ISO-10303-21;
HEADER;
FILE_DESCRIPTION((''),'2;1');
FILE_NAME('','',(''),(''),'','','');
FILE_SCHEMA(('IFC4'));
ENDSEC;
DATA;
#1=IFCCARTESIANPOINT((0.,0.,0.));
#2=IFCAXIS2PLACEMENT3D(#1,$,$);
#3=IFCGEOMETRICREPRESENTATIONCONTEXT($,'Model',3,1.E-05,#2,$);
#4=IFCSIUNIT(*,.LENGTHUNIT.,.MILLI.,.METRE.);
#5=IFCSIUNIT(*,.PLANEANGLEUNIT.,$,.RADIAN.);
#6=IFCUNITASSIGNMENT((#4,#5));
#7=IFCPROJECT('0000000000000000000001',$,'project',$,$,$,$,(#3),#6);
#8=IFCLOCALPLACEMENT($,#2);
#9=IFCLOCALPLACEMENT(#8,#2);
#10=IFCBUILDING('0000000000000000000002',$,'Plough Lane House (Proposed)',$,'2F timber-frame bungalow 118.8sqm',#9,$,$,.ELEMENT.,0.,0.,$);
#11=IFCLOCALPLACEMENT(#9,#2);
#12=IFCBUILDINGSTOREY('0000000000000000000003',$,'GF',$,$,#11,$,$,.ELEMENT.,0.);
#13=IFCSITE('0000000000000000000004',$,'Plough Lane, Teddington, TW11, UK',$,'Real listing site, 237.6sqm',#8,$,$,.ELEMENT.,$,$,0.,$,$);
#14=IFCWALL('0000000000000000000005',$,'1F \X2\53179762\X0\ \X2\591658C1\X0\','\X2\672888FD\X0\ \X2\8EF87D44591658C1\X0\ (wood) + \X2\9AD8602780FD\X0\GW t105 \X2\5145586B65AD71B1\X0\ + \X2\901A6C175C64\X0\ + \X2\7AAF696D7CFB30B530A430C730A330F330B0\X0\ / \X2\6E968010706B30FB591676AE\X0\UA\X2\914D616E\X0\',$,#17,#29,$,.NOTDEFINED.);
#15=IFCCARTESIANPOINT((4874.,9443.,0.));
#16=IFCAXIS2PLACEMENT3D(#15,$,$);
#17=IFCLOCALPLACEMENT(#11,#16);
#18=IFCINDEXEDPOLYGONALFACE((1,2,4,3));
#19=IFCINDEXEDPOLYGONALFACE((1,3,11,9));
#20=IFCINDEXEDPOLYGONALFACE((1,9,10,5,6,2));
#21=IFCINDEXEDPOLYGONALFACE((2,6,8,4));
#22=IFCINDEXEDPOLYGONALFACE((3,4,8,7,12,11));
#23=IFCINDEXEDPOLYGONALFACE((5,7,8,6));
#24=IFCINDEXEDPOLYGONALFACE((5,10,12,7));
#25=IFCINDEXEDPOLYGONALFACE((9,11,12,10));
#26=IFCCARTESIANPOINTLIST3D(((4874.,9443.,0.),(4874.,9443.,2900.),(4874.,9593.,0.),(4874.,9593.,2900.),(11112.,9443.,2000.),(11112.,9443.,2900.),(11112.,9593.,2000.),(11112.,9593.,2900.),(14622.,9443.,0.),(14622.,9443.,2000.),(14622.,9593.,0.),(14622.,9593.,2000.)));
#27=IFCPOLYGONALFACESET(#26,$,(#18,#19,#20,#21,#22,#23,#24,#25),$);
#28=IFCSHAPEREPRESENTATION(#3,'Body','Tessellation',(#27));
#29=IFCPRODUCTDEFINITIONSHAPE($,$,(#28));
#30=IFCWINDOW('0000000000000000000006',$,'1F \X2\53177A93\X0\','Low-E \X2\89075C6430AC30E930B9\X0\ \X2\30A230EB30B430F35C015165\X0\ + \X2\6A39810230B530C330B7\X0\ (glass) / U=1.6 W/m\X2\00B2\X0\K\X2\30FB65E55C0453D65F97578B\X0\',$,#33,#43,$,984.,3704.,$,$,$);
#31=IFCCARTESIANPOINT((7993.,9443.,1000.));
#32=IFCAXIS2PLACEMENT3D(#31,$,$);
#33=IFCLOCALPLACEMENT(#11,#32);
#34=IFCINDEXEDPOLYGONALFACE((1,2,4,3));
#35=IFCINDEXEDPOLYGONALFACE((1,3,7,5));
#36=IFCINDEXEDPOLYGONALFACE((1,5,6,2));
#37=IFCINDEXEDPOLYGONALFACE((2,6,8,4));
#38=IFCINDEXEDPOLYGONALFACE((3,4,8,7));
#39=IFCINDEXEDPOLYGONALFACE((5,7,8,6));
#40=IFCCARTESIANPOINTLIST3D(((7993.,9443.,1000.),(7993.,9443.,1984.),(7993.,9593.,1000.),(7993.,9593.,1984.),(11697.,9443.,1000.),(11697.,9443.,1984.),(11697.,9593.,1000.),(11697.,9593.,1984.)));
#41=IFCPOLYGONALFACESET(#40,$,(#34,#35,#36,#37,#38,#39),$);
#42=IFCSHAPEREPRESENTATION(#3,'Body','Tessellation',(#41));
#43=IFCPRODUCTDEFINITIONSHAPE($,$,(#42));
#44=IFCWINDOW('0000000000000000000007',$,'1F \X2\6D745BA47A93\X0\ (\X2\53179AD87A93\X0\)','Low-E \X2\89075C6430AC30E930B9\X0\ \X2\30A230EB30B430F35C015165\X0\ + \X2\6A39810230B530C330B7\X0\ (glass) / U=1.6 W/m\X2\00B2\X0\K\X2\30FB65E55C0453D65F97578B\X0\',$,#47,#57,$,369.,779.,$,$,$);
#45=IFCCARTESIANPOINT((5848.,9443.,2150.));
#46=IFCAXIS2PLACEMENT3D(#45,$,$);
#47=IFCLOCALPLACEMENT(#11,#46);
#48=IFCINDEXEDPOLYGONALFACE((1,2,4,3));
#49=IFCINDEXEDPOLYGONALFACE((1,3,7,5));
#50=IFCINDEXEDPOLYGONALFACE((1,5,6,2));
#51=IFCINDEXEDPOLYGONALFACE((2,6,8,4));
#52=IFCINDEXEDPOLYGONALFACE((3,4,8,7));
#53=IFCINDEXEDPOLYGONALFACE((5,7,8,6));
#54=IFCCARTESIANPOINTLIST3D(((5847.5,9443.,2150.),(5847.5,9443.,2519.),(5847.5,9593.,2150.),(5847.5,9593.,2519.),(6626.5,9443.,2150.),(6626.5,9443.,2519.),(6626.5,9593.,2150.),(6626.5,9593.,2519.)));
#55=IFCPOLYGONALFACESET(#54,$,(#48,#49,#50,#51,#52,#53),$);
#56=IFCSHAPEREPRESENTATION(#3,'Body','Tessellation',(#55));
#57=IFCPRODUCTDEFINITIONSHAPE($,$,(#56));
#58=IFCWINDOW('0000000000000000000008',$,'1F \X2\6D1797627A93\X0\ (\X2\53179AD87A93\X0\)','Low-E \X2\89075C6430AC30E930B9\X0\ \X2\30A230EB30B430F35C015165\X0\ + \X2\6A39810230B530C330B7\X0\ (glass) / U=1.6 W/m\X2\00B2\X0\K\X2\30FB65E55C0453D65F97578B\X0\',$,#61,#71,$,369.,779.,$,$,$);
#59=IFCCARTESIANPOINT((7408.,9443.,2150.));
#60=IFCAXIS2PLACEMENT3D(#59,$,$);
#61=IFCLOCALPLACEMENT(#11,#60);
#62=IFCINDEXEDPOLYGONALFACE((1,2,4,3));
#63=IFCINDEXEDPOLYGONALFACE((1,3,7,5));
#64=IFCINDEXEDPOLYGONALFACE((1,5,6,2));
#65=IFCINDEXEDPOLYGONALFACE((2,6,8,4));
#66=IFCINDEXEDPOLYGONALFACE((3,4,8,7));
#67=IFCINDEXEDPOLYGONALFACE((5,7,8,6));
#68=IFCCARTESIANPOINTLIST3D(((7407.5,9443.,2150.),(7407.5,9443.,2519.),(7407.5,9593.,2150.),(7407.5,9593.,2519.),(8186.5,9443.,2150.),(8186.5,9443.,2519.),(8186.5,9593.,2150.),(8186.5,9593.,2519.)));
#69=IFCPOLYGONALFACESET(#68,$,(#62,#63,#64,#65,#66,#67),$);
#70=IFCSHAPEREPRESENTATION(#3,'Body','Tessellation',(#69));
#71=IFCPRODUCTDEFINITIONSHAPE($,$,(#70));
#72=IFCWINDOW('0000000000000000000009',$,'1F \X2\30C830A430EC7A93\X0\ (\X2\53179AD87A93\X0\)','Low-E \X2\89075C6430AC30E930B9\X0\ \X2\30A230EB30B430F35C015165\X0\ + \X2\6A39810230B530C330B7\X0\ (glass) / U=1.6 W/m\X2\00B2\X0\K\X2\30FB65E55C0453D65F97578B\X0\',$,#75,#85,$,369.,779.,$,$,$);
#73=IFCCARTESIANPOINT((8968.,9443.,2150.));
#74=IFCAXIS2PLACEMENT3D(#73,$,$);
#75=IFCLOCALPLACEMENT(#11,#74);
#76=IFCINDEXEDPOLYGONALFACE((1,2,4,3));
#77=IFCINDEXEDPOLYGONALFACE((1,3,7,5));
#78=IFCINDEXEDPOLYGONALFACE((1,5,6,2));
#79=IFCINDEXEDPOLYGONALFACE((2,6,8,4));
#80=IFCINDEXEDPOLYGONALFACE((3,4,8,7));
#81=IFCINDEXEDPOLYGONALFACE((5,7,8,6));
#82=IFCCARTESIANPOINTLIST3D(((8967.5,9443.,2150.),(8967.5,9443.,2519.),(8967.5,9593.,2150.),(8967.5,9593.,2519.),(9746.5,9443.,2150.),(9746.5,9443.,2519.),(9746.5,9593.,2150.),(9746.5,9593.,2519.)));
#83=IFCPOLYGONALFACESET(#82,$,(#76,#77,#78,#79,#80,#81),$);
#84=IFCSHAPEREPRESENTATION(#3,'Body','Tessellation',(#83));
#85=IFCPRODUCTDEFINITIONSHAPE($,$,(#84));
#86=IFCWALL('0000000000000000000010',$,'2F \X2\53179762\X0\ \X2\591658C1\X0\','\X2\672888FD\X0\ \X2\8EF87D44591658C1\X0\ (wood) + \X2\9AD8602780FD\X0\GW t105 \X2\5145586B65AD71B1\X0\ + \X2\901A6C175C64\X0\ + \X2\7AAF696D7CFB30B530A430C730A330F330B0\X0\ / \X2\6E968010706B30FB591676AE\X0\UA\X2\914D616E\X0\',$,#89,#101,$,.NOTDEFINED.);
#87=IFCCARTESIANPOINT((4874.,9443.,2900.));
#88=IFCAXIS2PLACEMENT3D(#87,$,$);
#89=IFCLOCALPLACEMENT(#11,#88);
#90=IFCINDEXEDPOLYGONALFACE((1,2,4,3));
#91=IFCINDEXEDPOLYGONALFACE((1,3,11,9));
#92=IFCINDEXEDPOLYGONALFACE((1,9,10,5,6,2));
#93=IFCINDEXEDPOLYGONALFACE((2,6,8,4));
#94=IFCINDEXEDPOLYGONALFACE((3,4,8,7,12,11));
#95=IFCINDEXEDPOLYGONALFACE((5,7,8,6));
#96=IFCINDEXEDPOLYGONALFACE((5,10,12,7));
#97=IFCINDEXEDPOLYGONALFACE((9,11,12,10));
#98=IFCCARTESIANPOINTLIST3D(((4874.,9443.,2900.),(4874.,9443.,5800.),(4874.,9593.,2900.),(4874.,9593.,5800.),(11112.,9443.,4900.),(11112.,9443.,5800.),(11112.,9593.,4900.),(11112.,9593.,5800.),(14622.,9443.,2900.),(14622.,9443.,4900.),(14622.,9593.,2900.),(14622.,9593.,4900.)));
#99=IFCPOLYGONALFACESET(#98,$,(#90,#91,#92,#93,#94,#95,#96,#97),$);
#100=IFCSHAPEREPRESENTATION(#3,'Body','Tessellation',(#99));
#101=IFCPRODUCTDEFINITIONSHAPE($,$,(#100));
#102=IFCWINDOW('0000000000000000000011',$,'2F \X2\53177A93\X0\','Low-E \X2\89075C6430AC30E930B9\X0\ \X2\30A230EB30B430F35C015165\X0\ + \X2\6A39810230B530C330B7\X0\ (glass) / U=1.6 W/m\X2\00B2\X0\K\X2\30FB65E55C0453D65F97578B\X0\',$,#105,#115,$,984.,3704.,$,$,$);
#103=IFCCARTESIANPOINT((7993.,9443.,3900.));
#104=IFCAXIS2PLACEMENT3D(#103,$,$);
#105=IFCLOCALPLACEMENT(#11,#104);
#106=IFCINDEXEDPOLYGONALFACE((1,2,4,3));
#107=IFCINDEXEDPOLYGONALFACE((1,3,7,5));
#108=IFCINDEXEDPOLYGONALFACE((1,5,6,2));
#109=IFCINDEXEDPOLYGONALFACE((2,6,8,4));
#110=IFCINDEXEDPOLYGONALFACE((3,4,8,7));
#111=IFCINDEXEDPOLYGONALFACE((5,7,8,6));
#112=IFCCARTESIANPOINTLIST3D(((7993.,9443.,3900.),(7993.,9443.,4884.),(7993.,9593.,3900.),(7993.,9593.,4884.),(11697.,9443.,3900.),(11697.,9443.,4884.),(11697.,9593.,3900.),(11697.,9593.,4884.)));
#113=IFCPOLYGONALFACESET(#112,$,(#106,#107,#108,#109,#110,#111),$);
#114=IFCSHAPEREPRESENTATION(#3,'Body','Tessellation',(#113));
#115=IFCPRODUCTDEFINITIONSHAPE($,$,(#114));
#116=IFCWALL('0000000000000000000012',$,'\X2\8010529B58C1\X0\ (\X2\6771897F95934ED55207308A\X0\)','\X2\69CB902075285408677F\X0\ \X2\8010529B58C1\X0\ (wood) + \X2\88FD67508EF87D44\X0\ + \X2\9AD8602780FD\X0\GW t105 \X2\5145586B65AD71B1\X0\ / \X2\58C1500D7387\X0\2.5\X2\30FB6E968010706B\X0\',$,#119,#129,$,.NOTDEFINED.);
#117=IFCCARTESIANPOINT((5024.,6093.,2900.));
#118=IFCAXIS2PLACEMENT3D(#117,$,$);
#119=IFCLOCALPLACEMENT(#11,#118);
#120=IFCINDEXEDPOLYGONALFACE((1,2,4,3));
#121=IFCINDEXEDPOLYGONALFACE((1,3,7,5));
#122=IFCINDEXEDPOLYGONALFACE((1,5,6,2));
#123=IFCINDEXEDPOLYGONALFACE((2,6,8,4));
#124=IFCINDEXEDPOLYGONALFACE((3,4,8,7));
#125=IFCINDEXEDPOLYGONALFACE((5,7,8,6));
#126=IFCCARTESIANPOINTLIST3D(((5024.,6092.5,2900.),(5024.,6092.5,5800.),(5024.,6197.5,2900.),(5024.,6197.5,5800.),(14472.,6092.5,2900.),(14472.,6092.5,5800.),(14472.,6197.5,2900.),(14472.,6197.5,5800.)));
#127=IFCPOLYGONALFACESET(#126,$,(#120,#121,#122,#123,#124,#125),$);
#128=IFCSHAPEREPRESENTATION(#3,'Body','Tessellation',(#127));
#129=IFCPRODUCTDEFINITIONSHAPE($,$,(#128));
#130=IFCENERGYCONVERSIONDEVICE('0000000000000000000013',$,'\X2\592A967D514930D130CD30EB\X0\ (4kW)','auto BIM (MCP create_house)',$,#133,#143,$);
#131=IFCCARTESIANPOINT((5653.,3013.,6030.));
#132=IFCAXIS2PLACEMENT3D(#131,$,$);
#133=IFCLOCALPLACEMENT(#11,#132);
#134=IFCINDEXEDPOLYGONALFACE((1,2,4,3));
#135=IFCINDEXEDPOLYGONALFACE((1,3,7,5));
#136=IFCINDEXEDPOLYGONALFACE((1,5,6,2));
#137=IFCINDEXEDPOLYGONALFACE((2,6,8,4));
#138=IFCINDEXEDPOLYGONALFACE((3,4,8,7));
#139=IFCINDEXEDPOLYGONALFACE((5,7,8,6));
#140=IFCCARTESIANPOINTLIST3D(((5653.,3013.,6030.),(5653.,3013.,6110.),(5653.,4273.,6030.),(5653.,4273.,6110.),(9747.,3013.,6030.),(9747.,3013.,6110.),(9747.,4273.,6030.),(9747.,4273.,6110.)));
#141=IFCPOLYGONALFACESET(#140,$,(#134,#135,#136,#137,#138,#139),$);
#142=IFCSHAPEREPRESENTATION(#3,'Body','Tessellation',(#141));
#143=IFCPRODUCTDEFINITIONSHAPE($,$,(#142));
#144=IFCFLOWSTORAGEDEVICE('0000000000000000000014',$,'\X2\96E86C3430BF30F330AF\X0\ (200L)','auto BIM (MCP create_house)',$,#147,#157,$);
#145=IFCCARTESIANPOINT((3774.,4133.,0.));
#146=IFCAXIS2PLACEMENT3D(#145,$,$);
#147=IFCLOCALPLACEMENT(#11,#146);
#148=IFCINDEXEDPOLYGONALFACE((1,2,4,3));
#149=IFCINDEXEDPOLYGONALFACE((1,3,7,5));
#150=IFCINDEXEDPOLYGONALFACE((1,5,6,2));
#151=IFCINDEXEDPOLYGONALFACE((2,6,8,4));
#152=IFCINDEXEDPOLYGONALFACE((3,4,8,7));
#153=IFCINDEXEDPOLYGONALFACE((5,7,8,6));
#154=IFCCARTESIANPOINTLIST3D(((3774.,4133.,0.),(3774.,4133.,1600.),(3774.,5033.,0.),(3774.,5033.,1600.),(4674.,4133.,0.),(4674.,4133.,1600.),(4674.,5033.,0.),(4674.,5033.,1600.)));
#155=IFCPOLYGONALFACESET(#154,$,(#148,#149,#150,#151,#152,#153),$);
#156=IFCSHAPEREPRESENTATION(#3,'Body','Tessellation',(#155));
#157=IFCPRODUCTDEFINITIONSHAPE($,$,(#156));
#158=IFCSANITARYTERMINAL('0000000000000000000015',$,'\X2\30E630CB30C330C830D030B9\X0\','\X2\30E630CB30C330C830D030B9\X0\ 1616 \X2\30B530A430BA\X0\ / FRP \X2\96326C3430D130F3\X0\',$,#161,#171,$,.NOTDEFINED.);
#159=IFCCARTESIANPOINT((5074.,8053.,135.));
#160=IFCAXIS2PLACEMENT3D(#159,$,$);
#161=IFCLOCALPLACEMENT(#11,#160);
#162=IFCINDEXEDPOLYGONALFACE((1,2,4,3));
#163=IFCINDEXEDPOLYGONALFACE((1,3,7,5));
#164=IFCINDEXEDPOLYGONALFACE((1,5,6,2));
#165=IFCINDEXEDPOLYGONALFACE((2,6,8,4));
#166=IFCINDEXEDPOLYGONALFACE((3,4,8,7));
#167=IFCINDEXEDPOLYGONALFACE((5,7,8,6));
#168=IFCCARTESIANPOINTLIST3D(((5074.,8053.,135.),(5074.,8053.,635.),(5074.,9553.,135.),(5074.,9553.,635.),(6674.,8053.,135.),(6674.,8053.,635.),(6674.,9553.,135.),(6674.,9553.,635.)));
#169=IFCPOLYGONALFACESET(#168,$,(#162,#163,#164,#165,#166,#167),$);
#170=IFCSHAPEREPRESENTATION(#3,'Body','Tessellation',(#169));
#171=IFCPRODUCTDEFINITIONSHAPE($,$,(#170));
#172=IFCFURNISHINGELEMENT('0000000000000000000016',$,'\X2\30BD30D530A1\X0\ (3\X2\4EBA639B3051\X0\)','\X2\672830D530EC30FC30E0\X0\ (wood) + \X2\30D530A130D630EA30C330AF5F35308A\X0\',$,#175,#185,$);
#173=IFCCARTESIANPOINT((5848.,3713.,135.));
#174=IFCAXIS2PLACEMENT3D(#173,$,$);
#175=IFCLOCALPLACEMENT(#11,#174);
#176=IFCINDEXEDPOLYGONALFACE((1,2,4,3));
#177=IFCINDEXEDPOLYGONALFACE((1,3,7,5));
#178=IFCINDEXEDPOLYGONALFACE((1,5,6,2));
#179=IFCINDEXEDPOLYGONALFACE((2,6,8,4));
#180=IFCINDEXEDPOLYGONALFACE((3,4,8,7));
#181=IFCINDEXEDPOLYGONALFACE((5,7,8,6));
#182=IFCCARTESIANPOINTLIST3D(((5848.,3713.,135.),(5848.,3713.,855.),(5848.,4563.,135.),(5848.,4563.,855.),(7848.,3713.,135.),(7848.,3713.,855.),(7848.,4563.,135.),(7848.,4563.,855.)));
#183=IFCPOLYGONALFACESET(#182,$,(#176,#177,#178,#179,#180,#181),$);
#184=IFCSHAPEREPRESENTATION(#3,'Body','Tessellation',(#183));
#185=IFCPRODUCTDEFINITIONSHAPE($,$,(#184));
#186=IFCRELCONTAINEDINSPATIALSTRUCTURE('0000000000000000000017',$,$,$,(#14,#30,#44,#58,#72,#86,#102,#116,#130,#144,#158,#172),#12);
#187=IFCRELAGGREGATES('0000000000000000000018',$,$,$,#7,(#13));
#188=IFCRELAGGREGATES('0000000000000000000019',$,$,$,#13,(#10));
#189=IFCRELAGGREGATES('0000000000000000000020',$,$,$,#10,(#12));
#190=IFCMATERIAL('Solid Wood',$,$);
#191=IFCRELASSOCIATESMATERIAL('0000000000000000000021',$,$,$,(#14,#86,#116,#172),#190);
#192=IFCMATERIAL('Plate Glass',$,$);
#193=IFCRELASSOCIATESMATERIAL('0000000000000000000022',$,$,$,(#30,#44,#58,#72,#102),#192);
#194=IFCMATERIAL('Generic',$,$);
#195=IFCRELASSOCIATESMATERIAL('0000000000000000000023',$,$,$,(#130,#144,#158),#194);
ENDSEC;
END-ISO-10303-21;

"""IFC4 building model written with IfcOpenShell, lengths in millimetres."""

from ifc_helpers import new_model, si_unit, frame, frame_2d, origin, place, context, project, spatial, rectangle, extrude, material, element, fill, save


model = new_model("IFC4")

# Units and contexts
model_context = context("Model", 3, precision=1e-05, world=origin())
ifc_project = project(units=[si_unit("LENGTHUNIT", "METRE", prefix="MILLI"), si_unit("PLANEANGLEUNIT", "RADIAN")], contexts=[model_context])

# Site, building, storey
site_placement = place(None, origin())
site = spatial("IfcSite", under=ifc_project, at=site_placement, Name="Plough Lane, Teddington, TW11, UK", ObjectType="Real listing site, 237.6sqm", CompositionType="ELEMENT", RefElevation=0.0)
building_placement = place(site_placement, origin())
building = spatial("IfcBuilding", under=site, at=building_placement, Name="Plough Lane House (Proposed)", ObjectType="2F timber-frame bungalow 118.8sqm", CompositionType="ELEMENT", ElevationOfRefHeight=0.0, ElevationOfTerrain=0.0)
storey_placement = place(building_placement, origin())
storey = spatial("IfcBuildingStorey", under=building, at=storey_placement, Name="GF", CompositionType="ELEMENT", Elevation=0.0)

# Wall, openings, windows
ifc_material_1 = material(Name="Solid Wood")
wall_1_placement = place(storey_placement, frame((4874.0, 9443.0, 0.0)))
wall_1 = element("IfcWall", 1, at=wall_1_placement, inside=storey, material=ifc_material_1, Name="1F 北面 外壁", Description="木製 軸組外壁 (wood) + 高性能GW t105 充填断熱 + 通気層 + 窯業系サイディング / 準耐火・外皮UA配慮", PredefinedType="NOTDEFINED", context=model_context, shape_type="SweptSolid", body=[
    extrude(rectangle(XDim=9748.0, YDim=150.0, at=frame_2d((4874.0, 75.0))), frame((4874.0, 9443.0, 0.0)), (0.0, 0.0, 1.0), 2900.0),
])
opening_1_placement = place(storey_placement, frame((7993.0, 9443.0, 1000.0)))
opening_1 = element("IfcOpeningElement", 2, at=opening_1_placement, cuts=wall_1, PredefinedType="NOTDEFINED", context=model_context, shape_type="SweptSolid", body=[
    extrude(rectangle(XDim=3704.0, YDim=150.0, at=frame_2d((1852.0, 75.0))), frame((7993.0, 9443.0, 1000.0)), (0.0, 0.0, 1.0), 984.0),
])
opening_2_placement = place(storey_placement, frame((5848.0, 9443.0, 2150.0)))
opening_2 = element("IfcOpeningElement", 3, at=opening_2_placement, cuts=wall_1, PredefinedType="NOTDEFINED", context=model_context, shape_type="SweptSolid", body=[
    extrude(rectangle(XDim=779.0, YDim=150.0, at=frame_2d((389.0, 75.0))), frame((5848.0, 9443.0, 2150.0)), (0.0, 0.0, 1.0), 369.0),
])
opening_3_placement = place(storey_placement, frame((7408.0, 9443.0, 2150.0)))
opening_3 = element("IfcOpeningElement", 4, at=opening_3_placement, cuts=wall_1, PredefinedType="NOTDEFINED", context=model_context, shape_type="SweptSolid", body=[
    extrude(rectangle(XDim=779.0, YDim=150.0, at=frame_2d((389.0, 75.0))), frame((7408.0, 9443.0, 2150.0)), (0.0, 0.0, 1.0), 369.0),
])
opening_4_placement = place(storey_placement, frame((8968.0, 9443.0, 2150.0)))
opening_4 = element("IfcOpeningElement", 5, at=opening_4_placement, cuts=wall_1, PredefinedType="NOTDEFINED", context=model_context, shape_type="SweptSolid", body=[
    extrude(rectangle(XDim=779.0, YDim=150.0, at=frame_2d((389.0, 75.0))), frame((8968.0, 9443.0, 2150.0)), (0.0, 0.0, 1.0), 369.0),
])
ifc_material_2 = material(Name="Plate Glass")
window_1_placement = place(storey_placement, frame((7993.0, 9443.0, 1000.0)))
window_1 = element("IfcWindow", 6, at=window_1_placement, inside=storey, material=ifc_material_2, Name="1F 北窓", Description="Low-E 複層ガラス アルゴン封入 + 樹脂サッシ (glass) / U=1.6 W/m²K・日射取得型", OverallHeight=984.0, OverallWidth=3704.0, context=model_context, shape_type="SweptSolid", body=[
    extrude(rectangle(XDim=3704.0, YDim=150.0, at=frame_2d((1852.0, 75.0))), frame((7993.0, 9443.0, 1000.0)), (0.0, 0.0, 1.0), 984.0),
])
fill(opening_1, window_1)
window_2_placement = place(storey_placement, frame((5848.0, 9443.0, 2150.0)))
window_2 = element("IfcWindow", 7, at=window_2_placement, inside=storey, material=ifc_material_2, Name="1F 浴室窓 (北高窓)", Description="Low-E 複層ガラス アルゴン封入 + 樹脂サッシ (glass) / U=1.6 W/m²K・日射取得型", OverallHeight=369.0, OverallWidth=779.0, context=model_context, shape_type="SweptSolid", body=[
    extrude(rectangle(XDim=779.0, YDim=150.0, at=frame_2d((389.0, 75.0))), frame((5848.0, 9443.0, 2150.0)), (0.0, 0.0, 1.0), 369.0),
])
fill(opening_2, window_2)
window_3_placement = place(storey_placement, frame((7408.0, 9443.0, 2150.0)))
window_3 = element("IfcWindow", 8, at=window_3_placement, inside=storey, material=ifc_material_2, Name="1F 洗面窓 (北高窓)", Description="Low-E 複層ガラス アルゴン封入 + 樹脂サッシ (glass) / U=1.6 W/m²K・日射取得型", OverallHeight=369.0, OverallWidth=779.0, context=model_context, shape_type="SweptSolid", body=[
    extrude(rectangle(XDim=779.0, YDim=150.0, at=frame_2d((389.0, 75.0))), frame((7408.0, 9443.0, 2150.0)), (0.0, 0.0, 1.0), 369.0),
])
fill(opening_3, window_3)
window_4_placement = place(storey_placement, frame((8968.0, 9443.0, 2150.0)))
window_4 = element("IfcWindow", 9, at=window_4_placement, inside=storey, material=ifc_material_2, Name="1F トイレ窓 (北高窓)", Description="Low-E 複層ガラス アルゴン封入 + 樹脂サッシ (glass) / U=1.6 W/m²K・日射取得型", OverallHeight=369.0, OverallWidth=779.0, context=model_context, shape_type="SweptSolid", body=[
    extrude(rectangle(XDim=779.0, YDim=150.0, at=frame_2d((389.0, 75.0))), frame((8968.0, 9443.0, 2150.0)), (0.0, 0.0, 1.0), 369.0),
])
fill(opening_4, window_4)

# Wall, opening, window
wall_2_placement = place(storey_placement, frame((4874.0, 9443.0, 2900.0)))
wall_2 = element("IfcWall", 10, at=wall_2_placement, inside=storey, material=ifc_material_1, Name="2F 北面 外壁", Description="木製 軸組外壁 (wood) + 高性能GW t105 充填断熱 + 通気層 + 窯業系サイディング / 準耐火・外皮UA配慮", PredefinedType="NOTDEFINED", context=model_context, shape_type="SweptSolid", body=[
    extrude(rectangle(XDim=9748.0, YDim=150.0, at=frame_2d((4874.0, 75.0))), frame((4874.0, 9443.0, 2900.0)), (0.0, 0.0, 1.0), 2900.0),
])
opening_5_placement = place(storey_placement, frame((7993.0, 9443.0, 3900.0)))
opening_5 = element("IfcOpeningElement", 11, at=opening_5_placement, cuts=wall_2, PredefinedType="NOTDEFINED", context=model_context, shape_type="SweptSolid", body=[
    extrude(rectangle(XDim=3704.0, YDim=150.0, at=frame_2d((1852.0, 75.0))), frame((7993.0, 9443.0, 3900.0)), (0.0, 0.0, 1.0), 984.0),
])
window_5_placement = place(storey_placement, frame((7993.0, 9443.0, 3900.0)))
window_5 = element("IfcWindow", 12, at=window_5_placement, inside=storey, material=ifc_material_2, Name="2F 北窓", Description="Low-E 複層ガラス アルゴン封入 + 樹脂サッシ (glass) / U=1.6 W/m²K・日射取得型", OverallHeight=984.0, OverallWidth=3704.0, context=model_context, shape_type="SweptSolid", body=[
    extrude(rectangle(XDim=3704.0, YDim=150.0, at=frame_2d((1852.0, 75.0))), frame((7993.0, 9443.0, 3900.0)), (0.0, 0.0, 1.0), 984.0),
])
fill(opening_5, window_5)

# Wall
wall_3_placement = place(storey_placement, frame((5024.0, 6093.0, 2900.0)))
element("IfcWall", 13, at=wall_3_placement, inside=storey, material=ifc_material_1, Name="耐力壁 (東西間仕切り)", Description="構造用合板 耐力壁 (wood) + 製材軸組 + 高性能GW t105 充填断熱 / 壁倍率2.5・準耐火", PredefinedType="NOTDEFINED", context=model_context, shape_type="SweptSolid", body=[
    extrude(rectangle(XDim=9448.0, YDim=105.0, at=frame_2d((4724.0, 52.0))), frame((5024.0, 6093.0, 2900.0)), (0.0, 0.0, 1.0), 2900.0),
])

# Energy conversion device
ifc_material_3 = material(Name="Generic")
energy_conversion_device_placement = place(storey_placement, frame((5653.0, 3013.0, 6030.0)))
element("IfcEnergyConversionDevice", 14, at=energy_conversion_device_placement, inside=storey, material=ifc_material_3, Name="太陽光パネル (4kW)", Description="auto BIM (MCP create_house)", context=model_context, shape_type="SweptSolid", body=[
    extrude(rectangle(XDim=4094.0, YDim=1260.0, at=frame_2d((2047.0, 630.0))), frame((5653.0, 3013.0, 6030.0)), (0.0, 0.0, 1.0), 80.0),
])

# Flow storage device
flow_storage_device_placement = place(storey_placement, frame((3774.0, 4133.0, 0.0)))
element("IfcFlowStorageDevice", 15, at=flow_storage_device_placement, inside=storey, material=ifc_material_3, Name="雨水タンク (200L)", Description="auto BIM (MCP create_house)", context=model_context, shape_type="SweptSolid", body=[
    extrude(rectangle(XDim=900.0, YDim=900.0, at=frame_2d((450.0, 450.0))), frame((3774.0, 4133.0, 0.0)), (0.0, 0.0, 1.0), 1600.0),
])

# Sanitary terminal
sanitary_terminal_placement = place(storey_placement, frame((5074.0, 8053.0, 135.0)))
element("IfcSanitaryTerminal", 16, at=sanitary_terminal_placement, inside=storey, material=ifc_material_3, Name="ユニットバス", Description="ユニットバス 1616 サイズ / FRP 防水パン", PredefinedType="NOTDEFINED", context=model_context, shape_type="SweptSolid", body=[
    extrude(rectangle(XDim=1600.0, YDim=1500.0, at=frame_2d((800.0, 750.0))), frame((5074.0, 8053.0, 135.0)), (0.0, 0.0, 1.0), 500.0),
])

# Furnishing element
furnishing_1_placement = place(storey_placement, frame((5848.0, 3713.0, 135.0)))
element("IfcFurnishingElement", 17, at=furnishing_1_placement, inside=storey, material=ifc_material_1, Name="ソファ (3人掛け)", Description="木フレーム (wood) + ファブリック張り", context=model_context, shape_type="SweptSolid", body=[
    extrude(rectangle(XDim=2000.0, YDim=850.0, at=frame_2d((1000.0, 425.0))), frame((5848.0, 3713.0, 135.0)), (0.0, 0.0, 1.0), 720.0),
])

save(model, "model.ifc")
